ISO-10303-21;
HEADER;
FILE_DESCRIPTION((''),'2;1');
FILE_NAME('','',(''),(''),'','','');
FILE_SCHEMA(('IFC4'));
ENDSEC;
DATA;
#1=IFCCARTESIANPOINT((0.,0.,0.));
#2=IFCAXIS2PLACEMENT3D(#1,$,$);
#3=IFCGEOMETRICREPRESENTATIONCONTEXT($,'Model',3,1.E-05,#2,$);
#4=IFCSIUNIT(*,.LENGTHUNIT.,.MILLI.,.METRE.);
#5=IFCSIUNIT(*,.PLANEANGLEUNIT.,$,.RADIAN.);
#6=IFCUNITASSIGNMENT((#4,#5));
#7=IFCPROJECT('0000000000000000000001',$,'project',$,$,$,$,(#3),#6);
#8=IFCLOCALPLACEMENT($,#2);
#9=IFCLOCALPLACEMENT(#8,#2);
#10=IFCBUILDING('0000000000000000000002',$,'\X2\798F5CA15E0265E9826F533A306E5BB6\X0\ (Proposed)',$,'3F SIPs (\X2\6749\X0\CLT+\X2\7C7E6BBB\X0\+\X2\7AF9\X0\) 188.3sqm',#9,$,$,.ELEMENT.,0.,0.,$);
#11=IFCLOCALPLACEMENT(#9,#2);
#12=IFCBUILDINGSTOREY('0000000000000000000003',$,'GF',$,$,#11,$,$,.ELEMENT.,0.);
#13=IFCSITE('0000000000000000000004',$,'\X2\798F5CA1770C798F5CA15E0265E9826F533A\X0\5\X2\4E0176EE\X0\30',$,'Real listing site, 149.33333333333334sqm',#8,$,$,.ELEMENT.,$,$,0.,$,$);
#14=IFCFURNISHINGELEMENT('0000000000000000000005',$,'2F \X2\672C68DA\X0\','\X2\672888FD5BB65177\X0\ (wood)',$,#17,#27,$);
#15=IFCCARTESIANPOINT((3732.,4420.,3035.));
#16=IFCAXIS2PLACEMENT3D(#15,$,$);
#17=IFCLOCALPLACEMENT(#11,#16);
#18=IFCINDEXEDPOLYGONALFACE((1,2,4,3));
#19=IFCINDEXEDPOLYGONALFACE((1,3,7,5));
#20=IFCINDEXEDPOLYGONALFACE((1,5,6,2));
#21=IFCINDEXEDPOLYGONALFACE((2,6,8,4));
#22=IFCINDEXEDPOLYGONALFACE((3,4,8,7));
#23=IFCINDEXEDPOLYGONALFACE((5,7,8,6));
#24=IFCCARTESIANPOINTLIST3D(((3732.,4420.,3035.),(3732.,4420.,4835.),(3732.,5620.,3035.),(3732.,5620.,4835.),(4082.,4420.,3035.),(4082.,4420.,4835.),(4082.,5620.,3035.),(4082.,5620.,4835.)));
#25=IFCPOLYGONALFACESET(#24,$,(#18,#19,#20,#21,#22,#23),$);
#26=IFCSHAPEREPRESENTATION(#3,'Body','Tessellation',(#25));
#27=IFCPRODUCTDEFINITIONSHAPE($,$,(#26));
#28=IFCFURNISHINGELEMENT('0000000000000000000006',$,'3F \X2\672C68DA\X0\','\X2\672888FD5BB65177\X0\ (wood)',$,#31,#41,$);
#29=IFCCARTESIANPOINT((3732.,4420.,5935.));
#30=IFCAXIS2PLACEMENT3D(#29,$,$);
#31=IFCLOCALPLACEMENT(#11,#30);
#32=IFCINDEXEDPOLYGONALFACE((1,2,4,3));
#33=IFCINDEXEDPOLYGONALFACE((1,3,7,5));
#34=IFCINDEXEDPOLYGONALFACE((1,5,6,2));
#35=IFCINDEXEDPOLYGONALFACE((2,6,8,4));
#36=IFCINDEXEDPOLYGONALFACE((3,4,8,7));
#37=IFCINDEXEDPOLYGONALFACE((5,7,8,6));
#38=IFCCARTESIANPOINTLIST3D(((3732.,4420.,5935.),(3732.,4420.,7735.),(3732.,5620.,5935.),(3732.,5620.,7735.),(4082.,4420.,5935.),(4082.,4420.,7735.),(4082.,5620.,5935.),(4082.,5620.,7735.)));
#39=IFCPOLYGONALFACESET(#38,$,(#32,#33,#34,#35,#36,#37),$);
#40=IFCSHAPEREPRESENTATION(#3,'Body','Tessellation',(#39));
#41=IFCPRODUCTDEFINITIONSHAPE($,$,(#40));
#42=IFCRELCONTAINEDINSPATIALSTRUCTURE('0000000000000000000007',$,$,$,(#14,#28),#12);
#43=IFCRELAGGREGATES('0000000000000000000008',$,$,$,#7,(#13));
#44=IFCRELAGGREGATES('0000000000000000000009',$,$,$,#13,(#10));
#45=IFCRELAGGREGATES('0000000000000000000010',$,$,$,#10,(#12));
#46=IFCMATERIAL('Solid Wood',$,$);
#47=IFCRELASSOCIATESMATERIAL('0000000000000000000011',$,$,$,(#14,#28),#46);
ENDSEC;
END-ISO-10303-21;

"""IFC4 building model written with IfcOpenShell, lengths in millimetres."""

from ifc_helpers import new_model, si_unit, frame, frame_2d, origin, place, context, project, spatial, rectangle, extrude, material, element, save


model = new_model("IFC4")

# Units and contexts
model_context = context("Model", 3, precision=1e-05, world=origin())
ifc_project = project(units=[si_unit("LENGTHUNIT", "METRE", prefix="MILLI"), si_unit("PLANEANGLEUNIT", "RADIAN")], contexts=[model_context])

# Site, building, storey
site_placement = place(None, origin())
site = spatial("IfcSite", under=ifc_project, at=site_placement, Name="福岡県福岡市早良区5丁目30", ObjectType="Real listing site, 149.33333333333334sqm", CompositionType="ELEMENT", RefElevation=0.0)
building_placement = place(site_placement, origin())
building = spatial("IfcBuilding", under=site, at=building_placement, Name="福岡市早良区の家 (Proposed)", ObjectType="3F SIPs (杉CLT+籾殻+竹) 188.3sqm", CompositionType="ELEMENT", ElevationOfRefHeight=0.0, ElevationOfTerrain=0.0)
storey_placement = place(building_placement, origin())
storey = spatial("IfcBuildingStorey", under=building, at=storey_placement, Name="GF", CompositionType="ELEMENT", Elevation=0.0)

# Shared definitions
ifc_material_1 = material(Name="Solid Wood")

# Furnishing elements
furnishing_1_placement = place(storey_placement, frame((3732.0, 4420.0, 3035.0)))
element("IfcFurnishingElement", 1, at=furnishing_1_placement, inside=storey, material=ifc_material_1, Name="2F 本棚", Description="木製家具 (wood)", context=model_context, shape_type="SweptSolid", body=[
    extrude(rectangle(XDim=350.0, YDim=1200.0, at=frame_2d((175.0, 600.0))), frame((3732.0, 4420.0, 3035.0)), (0.0, 0.0, 1.0), 1800.0),
])
furnishing_2_placement = place(storey_placement, frame((3732.0, 4420.0, 5935.0)))
element("IfcFurnishingElement", 2, at=furnishing_2_placement, inside=storey, material=ifc_material_1, Name="3F 本棚", Description="木製家具 (wood)", context=model_context, shape_type="SweptSolid", body=[
    extrude(rectangle(XDim=350.0, YDim=1200.0, at=frame_2d((175.0, 600.0))), frame((3732.0, 4420.0, 5935.0)), (0.0, 0.0, 1.0), 1800.0),
])

save(model, "model.ifc")
